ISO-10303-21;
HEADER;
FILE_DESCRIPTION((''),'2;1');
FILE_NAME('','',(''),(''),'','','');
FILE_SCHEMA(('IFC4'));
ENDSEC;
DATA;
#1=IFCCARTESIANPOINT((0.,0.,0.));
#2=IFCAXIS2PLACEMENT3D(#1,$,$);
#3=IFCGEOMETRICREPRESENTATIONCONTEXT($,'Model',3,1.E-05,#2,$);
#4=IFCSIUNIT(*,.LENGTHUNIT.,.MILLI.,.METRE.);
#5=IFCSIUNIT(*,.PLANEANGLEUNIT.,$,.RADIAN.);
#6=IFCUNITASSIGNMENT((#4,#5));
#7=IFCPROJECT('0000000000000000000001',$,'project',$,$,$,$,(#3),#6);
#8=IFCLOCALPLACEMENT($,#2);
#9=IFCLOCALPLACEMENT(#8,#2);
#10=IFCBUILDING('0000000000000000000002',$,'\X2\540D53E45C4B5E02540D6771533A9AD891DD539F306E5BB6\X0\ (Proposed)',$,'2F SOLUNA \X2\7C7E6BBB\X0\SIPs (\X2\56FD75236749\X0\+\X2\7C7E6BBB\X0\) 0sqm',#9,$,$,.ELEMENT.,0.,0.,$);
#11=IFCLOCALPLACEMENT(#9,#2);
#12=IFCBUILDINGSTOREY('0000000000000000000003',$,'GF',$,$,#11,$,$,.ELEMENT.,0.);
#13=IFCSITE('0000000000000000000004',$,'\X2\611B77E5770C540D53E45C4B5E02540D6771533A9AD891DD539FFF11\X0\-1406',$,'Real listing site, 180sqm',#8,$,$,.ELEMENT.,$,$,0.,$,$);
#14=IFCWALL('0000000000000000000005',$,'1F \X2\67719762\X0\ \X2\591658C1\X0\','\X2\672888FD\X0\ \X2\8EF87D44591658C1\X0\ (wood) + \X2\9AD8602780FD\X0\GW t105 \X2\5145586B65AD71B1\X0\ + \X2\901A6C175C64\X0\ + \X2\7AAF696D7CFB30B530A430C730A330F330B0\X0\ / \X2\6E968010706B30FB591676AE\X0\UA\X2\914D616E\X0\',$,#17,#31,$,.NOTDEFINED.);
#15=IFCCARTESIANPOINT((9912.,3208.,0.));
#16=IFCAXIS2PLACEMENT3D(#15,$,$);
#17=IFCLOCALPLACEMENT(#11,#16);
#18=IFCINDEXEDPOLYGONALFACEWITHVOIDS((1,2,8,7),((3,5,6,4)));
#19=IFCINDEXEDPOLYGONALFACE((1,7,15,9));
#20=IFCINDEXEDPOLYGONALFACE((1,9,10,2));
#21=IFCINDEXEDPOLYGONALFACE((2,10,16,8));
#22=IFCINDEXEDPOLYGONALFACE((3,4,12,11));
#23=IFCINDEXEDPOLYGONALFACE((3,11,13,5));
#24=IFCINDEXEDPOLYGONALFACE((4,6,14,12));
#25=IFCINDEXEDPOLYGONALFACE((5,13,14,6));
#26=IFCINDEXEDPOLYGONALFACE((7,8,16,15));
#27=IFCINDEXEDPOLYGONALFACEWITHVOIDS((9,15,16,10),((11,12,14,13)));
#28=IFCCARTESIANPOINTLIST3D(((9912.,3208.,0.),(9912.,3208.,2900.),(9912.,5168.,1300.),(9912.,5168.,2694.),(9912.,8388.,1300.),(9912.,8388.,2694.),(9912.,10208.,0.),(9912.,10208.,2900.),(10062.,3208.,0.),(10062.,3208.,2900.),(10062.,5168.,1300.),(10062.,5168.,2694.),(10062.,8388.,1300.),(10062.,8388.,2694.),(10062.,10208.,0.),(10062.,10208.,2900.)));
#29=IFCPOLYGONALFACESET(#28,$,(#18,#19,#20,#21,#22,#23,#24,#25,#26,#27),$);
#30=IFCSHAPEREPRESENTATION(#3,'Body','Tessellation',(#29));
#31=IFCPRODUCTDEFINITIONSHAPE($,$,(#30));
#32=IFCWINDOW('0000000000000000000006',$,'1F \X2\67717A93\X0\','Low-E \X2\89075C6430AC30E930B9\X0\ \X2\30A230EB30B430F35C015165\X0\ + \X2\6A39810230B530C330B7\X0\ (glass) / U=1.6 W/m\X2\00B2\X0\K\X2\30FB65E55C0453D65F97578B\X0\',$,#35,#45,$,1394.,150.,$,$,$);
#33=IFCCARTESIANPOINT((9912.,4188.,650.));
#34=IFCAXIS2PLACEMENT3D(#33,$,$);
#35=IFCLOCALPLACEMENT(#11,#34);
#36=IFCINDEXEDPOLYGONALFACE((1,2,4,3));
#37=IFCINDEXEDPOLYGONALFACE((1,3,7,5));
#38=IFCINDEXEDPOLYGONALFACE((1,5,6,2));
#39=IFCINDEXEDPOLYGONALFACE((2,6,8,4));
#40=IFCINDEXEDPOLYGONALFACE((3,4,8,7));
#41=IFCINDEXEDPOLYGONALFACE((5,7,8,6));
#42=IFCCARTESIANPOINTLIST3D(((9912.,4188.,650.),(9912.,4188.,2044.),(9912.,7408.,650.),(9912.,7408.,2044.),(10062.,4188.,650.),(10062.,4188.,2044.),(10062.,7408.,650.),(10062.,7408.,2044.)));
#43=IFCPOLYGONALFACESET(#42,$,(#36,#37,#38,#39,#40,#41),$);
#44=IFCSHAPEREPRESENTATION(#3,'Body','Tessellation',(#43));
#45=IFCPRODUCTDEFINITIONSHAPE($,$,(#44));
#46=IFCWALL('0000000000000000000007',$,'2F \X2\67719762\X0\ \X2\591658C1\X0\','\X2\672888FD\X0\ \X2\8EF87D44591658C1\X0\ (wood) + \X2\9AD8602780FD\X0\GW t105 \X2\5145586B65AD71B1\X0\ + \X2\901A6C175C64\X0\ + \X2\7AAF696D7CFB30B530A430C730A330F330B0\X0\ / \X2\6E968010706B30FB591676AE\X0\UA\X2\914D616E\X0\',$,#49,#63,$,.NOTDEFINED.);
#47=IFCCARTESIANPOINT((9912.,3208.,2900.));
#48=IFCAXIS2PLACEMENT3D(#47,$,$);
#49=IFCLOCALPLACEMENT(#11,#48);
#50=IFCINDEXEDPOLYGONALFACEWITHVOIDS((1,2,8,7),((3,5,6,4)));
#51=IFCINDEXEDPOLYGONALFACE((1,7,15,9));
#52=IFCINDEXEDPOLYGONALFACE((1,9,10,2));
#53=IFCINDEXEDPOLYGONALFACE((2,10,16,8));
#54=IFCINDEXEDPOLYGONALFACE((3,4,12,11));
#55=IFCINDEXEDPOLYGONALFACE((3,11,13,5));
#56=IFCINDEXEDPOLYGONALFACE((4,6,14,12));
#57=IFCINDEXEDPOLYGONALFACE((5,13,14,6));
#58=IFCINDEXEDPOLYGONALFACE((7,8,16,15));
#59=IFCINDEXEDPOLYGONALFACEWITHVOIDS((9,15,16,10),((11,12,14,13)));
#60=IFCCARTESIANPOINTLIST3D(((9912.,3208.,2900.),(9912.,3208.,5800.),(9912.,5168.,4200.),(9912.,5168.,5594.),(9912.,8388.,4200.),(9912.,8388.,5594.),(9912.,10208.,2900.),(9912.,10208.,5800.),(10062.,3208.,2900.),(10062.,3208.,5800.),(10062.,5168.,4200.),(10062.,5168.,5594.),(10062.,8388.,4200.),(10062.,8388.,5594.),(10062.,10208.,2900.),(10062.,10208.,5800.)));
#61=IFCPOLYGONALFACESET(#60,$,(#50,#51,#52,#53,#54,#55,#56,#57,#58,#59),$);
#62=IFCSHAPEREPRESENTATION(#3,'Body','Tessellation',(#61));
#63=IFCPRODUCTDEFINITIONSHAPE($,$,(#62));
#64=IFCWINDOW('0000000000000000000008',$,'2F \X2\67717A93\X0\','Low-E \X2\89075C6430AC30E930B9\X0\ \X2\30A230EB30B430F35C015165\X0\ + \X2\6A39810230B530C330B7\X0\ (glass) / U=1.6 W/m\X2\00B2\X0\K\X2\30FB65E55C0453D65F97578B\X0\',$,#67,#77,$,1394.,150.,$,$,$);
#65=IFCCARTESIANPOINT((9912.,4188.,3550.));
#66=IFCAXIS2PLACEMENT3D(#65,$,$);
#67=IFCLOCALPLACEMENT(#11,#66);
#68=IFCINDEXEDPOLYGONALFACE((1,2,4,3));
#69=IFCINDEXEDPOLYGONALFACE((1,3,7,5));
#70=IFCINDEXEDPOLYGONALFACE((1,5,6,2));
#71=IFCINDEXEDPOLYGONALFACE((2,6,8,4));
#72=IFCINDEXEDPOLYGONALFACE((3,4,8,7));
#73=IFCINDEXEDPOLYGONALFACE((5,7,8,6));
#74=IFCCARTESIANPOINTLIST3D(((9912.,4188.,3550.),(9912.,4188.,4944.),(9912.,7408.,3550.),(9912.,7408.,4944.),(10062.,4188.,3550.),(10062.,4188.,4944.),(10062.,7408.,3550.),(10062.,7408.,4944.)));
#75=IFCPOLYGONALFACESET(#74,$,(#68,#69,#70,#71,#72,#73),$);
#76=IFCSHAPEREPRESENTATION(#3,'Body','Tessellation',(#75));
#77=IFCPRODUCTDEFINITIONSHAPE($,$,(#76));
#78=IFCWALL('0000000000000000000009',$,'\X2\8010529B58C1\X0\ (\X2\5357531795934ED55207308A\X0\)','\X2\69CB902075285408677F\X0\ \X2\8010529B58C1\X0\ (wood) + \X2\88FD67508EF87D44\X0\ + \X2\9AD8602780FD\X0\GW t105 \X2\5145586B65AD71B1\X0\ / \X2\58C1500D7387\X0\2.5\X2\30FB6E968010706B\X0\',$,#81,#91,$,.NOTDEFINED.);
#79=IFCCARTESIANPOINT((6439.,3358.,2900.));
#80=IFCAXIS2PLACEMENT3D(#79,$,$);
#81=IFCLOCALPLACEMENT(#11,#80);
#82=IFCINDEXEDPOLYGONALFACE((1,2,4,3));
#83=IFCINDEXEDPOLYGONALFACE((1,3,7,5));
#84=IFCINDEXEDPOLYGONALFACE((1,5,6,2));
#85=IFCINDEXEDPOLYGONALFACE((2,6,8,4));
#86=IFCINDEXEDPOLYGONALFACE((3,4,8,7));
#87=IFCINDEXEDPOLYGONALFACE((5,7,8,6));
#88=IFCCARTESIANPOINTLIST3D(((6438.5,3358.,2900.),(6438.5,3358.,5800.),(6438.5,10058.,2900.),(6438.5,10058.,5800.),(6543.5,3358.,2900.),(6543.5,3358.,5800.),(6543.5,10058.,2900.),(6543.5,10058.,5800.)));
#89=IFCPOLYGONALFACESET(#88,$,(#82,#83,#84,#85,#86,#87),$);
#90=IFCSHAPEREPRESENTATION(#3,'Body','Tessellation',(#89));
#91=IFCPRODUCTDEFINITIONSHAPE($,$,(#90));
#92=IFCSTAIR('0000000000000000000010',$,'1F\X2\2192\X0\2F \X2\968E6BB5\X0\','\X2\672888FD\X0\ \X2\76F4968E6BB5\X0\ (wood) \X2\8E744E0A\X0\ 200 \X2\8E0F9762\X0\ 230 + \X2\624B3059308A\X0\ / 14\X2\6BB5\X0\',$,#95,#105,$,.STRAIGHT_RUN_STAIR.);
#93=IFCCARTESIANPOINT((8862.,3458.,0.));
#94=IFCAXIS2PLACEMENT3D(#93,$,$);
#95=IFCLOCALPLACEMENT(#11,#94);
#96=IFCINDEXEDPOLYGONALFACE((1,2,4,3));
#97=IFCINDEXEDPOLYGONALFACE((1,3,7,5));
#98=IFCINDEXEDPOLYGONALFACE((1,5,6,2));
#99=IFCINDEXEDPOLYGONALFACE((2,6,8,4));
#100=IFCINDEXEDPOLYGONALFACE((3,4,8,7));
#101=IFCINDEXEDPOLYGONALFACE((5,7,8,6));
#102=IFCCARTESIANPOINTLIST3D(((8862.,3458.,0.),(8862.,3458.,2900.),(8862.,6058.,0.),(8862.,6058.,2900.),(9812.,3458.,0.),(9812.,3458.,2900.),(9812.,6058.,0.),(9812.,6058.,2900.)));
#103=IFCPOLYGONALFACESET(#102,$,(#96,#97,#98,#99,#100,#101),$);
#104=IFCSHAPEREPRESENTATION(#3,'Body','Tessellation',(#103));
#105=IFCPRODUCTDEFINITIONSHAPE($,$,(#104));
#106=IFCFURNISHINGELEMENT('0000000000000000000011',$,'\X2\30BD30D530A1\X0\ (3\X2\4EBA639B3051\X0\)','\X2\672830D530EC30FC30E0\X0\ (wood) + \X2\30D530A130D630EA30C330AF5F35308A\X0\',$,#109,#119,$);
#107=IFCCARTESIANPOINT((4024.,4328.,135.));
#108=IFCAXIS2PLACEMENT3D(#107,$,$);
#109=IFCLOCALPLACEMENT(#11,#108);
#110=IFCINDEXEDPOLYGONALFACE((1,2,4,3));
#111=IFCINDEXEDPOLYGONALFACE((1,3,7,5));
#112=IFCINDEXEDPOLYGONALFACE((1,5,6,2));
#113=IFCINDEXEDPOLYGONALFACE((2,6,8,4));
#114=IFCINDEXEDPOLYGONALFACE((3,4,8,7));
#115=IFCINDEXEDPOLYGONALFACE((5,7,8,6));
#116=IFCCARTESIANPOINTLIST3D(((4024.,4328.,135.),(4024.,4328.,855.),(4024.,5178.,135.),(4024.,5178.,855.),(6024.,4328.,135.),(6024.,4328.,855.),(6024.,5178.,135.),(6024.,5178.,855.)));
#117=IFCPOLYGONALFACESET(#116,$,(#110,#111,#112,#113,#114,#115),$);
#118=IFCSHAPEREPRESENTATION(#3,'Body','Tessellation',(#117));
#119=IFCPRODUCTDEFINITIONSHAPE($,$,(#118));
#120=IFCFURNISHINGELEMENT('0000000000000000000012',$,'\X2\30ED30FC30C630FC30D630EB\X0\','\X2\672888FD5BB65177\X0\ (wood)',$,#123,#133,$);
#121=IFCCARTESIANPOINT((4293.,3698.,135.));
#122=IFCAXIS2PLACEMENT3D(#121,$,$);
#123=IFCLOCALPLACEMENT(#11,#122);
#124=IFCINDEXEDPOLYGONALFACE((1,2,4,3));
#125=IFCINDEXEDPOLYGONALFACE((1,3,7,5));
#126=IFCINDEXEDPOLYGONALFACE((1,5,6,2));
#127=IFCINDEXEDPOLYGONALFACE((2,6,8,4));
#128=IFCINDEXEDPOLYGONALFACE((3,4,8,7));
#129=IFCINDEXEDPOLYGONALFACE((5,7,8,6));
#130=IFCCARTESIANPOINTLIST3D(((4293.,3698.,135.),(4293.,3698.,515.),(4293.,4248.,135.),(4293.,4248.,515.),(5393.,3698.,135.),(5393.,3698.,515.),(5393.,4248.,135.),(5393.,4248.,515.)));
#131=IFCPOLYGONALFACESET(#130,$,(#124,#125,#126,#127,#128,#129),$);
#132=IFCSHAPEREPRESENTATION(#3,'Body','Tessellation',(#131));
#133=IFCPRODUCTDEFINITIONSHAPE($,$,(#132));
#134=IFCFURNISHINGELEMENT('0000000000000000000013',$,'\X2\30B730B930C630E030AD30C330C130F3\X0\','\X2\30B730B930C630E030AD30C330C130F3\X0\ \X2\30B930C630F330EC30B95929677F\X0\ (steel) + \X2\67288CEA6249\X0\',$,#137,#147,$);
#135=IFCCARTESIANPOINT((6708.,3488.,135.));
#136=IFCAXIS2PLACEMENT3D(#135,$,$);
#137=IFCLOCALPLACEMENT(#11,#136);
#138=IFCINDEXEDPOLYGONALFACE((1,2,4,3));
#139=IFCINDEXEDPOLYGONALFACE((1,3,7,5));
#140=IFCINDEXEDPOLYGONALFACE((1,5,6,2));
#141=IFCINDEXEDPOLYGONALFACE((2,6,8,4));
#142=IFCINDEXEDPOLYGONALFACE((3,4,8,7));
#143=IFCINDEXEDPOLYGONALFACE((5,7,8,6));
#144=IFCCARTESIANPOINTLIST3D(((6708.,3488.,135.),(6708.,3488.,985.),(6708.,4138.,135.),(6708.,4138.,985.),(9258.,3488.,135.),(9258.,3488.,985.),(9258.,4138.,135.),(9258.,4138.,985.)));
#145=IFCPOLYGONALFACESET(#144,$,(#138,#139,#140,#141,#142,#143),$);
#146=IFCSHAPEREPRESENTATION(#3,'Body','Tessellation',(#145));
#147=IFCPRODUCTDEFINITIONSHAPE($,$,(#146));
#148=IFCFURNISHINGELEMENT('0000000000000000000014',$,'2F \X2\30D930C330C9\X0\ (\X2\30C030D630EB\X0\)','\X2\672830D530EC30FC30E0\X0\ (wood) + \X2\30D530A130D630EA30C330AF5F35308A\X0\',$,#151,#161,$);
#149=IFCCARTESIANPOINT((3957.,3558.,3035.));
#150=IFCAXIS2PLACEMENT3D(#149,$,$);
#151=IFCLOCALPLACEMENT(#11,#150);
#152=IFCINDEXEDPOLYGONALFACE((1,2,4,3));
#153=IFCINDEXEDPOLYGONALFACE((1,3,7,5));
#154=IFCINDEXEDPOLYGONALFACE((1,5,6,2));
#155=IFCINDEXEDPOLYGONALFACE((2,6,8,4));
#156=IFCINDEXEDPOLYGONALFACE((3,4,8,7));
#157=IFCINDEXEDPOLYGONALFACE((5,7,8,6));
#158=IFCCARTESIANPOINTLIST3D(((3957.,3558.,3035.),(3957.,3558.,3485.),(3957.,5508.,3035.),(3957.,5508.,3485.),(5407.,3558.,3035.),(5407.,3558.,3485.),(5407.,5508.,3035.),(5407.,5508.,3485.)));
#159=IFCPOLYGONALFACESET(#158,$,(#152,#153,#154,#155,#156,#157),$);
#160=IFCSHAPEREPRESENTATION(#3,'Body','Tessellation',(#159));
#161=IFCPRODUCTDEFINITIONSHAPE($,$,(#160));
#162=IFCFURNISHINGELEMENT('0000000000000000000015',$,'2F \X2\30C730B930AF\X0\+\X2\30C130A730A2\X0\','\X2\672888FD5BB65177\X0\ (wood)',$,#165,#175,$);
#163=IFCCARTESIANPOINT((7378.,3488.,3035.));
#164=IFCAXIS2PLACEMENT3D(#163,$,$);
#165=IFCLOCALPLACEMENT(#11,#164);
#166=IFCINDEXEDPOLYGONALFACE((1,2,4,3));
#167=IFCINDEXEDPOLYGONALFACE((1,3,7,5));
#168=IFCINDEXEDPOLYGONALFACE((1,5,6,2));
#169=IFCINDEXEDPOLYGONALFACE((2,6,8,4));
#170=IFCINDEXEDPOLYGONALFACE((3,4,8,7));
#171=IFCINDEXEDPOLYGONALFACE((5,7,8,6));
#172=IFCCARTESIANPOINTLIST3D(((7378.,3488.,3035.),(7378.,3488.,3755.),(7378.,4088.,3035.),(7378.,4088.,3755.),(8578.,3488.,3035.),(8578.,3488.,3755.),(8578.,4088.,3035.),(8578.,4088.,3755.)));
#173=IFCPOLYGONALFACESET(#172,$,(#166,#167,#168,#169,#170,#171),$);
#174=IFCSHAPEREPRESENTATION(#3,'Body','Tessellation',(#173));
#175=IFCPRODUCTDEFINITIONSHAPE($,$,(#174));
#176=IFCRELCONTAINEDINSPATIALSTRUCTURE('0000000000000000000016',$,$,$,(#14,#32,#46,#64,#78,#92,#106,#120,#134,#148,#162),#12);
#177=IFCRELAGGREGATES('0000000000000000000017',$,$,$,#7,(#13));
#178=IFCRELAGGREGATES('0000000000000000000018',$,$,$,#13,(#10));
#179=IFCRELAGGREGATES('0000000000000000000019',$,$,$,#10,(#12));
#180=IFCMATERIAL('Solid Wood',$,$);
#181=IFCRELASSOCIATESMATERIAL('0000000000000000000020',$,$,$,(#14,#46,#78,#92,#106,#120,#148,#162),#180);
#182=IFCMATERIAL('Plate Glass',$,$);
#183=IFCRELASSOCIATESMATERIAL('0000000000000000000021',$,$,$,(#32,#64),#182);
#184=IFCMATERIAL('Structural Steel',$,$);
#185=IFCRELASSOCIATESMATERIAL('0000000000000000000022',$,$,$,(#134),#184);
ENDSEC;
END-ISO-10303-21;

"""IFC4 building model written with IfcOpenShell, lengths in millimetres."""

from ifc_helpers import new_model, si_unit, frame, frame_2d, origin, place, context, project, spatial, rectangle, extrude, material, element, fill, save


model = new_model("IFC4")

# Units and contexts
model_context = context("Model", 3, precision=1e-05, world=origin())
ifc_project = project(units=[si_unit("LENGTHUNIT", "METRE", prefix="MILLI"), si_unit("PLANEANGLEUNIT", "RADIAN")], contexts=[model_context])

# Site, building, storey
site_placement = place(None, origin())
site = spatial("IfcSite", under=ifc_project, at=site_placement, Name="愛知県名古屋市名東区高針原１-1406", ObjectType="Real listing site, 180sqm", CompositionType="ELEMENT", RefElevation=0.0)
building_placement = place(site_placement, origin())
building = spatial("IfcBuilding", under=site, at=building_placement, Name="名古屋市名東区高針原の家 (Proposed)", ObjectType="2F SOLUNA 籾殻SIPs (国産杉+籾殻) 0sqm", CompositionType="ELEMENT", ElevationOfRefHeight=0.0, ElevationOfTerrain=0.0)
storey_placement = place(building_placement, origin())
storey = spatial("IfcBuildingStorey", under=building, at=storey_placement, Name="GF", CompositionType="ELEMENT", Elevation=0.0)

# Wall, opening, window
ifc_material_1 = material(Name="Solid Wood")
wall_1_placement = place(storey_placement, frame((9912.0, 3208.0, 0.0)))
wall_1 = element("IfcWall", 1, at=wall_1_placement, inside=storey, material=ifc_material_1, Name="1F 東面 外壁", Description="木製 軸組外壁 (wood) + 高性能GW t105 充填断熱 + 通気層 + 窯業系サイディング / 準耐火・外皮UA配慮", PredefinedType="NOTDEFINED", context=model_context, shape_type="SweptSolid", body=[
    extrude(rectangle(XDim=150.0, YDim=7000.0, at=frame_2d((75.0, 3500.0))), frame((9912.0, 3208.0, 0.0)), (0.0, 0.0, 1.0), 2900.0),
])
opening_1_placement = place(storey_placement, frame((9912.0, 4188.0, 650.0)))
opening_1 = element("IfcOpeningElement", 2, at=opening_1_placement, cuts=wall_1, PredefinedType="NOTDEFINED", context=model_context, shape_type="SweptSolid", body=[
    extrude(rectangle(XDim=150.0, YDim=3220.0, at=frame_2d((75.0, 1610.0))), frame((9912.0, 4188.0, 650.0)), (0.0, 0.0, 1.0), 1394.0),
])
ifc_material_2 = material(Name="Plate Glass")
window_1_placement = place(storey_placement, frame((9912.0, 4188.0, 650.0)))
window_1 = element("IfcWindow", 3, at=window_1_placement, inside=storey, material=ifc_material_2, Name="1F 東窓", Description="Low-E 複層ガラス アルゴン封入 + 樹脂サッシ (glass) / U=1.6 W/m²K・日射取得型", OverallHeight=1394.0, OverallWidth=150.0, context=model_context, shape_type="SweptSolid", body=[
    extrude(rectangle(XDim=150.0, YDim=3220.0, at=frame_2d((75.0, 1610.0))), frame((9912.0, 4188.0, 650.0)), (0.0, 0.0, 1.0), 1394.0),
])
fill(opening_1, window_1)

# Wall, opening, window
wall_2_placement = place(storey_placement, frame((9912.0, 3208.0, 2900.0)))
wall_2 = element("IfcWall", 4, at=wall_2_placement, inside=storey, material=ifc_material_1, Name="2F 東面 外壁", Description="木製 軸組外壁 (wood) + 高性能GW t105 充填断熱 + 通気層 + 窯業系サイディング / 準耐火・外皮UA配慮", PredefinedType="NOTDEFINED", context=model_context, shape_type="SweptSolid", body=[
    extrude(rectangle(XDim=150.0, YDim=7000.0, at=frame_2d((75.0, 3500.0))), frame((9912.0, 3208.0, 2900.0)), (0.0, 0.0, 1.0), 2900.0),
])
opening_2_placement = place(storey_placement, frame((9912.0, 4188.0, 3550.0)))
opening_2 = element("IfcOpeningElement", 5, at=opening_2_placement, cuts=wall_2, PredefinedType="NOTDEFINED", context=model_context, shape_type="SweptSolid", body=[
    extrude(rectangle(XDim=150.0, YDim=3220.0, at=frame_2d((75.0, 1610.0))), frame((9912.0, 4188.0, 3550.0)), (0.0, 0.0, 1.0), 1394.0),
])
window_2_placement = place(storey_placement, frame((9912.0, 4188.0, 3550.0)))
window_2 = element("IfcWindow", 6, at=window_2_placement, inside=storey, material=ifc_material_2, Name="2F 東窓", Description="Low-E 複層ガラス アルゴン封入 + 樹脂サッシ (glass) / U=1.6 W/m²K・日射取得型", OverallHeight=1394.0, OverallWidth=150.0, context=model_context, shape_type="SweptSolid", body=[
    extrude(rectangle(XDim=150.0, YDim=3220.0, at=frame_2d((75.0, 1610.0))), frame((9912.0, 4188.0, 3550.0)), (0.0, 0.0, 1.0), 1394.0),
])
fill(opening_2, window_2)

# Wall
wall_3_placement = place(storey_placement, frame((6439.0, 3358.0, 2900.0)))
element("IfcWall", 7, at=wall_3_placement, inside=storey, material=ifc_material_1, Name="耐力壁 (南北間仕切り)", Description="構造用合板 耐力壁 (wood) + 製材軸組 + 高性能GW t105 充填断熱 / 壁倍率2.5・準耐火", PredefinedType="NOTDEFINED", context=model_context, shape_type="SweptSolid", body=[
    extrude(rectangle(XDim=105.0, YDim=6700.0, at=frame_2d((52.0, 3350.0))), frame((6439.0, 3358.0, 2900.0)), (0.0, 0.0, 1.0), 2900.0),
])

# Stair
stair_placement = place(storey_placement, frame((8862.0, 3458.0, 0.0)))
element("IfcStair", 8, at=stair_placement, inside=storey, material=ifc_material_1, Name="1F→2F 階段", Description="木製 直階段 (wood) 蹴上 200 踏面 230 + 手すり / 14段", PredefinedType="STRAIGHT_RUN_STAIR", context=model_context, shape_type="SweptSolid", body=[
    extrude(rectangle(XDim=950.0, YDim=2600.0, at=frame_2d((475.0, 1300.0))), frame((8862.0, 3458.0, 0.0)), (0.0, 0.0, 1.0), 2900.0),
])

# Furnishing elements
furnishing_1_placement = place(storey_placement, frame((4024.0, 4328.0, 135.0)))
element("IfcFurnishingElement", 9, at=furnishing_1_placement, inside=storey, material=ifc_material_1, Name="ソファ (3人掛け)", Description="木フレーム (wood) + ファブリック張り", context=model_context, shape_type="SweptSolid", body=[
    extrude(rectangle(XDim=2000.0, YDim=850.0, at=frame_2d((1000.0, 425.0))), frame((4024.0, 4328.0, 135.0)), (0.0, 0.0, 1.0), 720.0),
])
furnishing_2_placement = place(storey_placement, frame((4293.0, 3698.0, 135.0)))
element("IfcFurnishingElement", 10, at=furnishing_2_placement, inside=storey, material=ifc_material_1, Name="ローテーブル", Description="木製家具 (wood)", context=model_context, shape_type="SweptSolid", body=[
    extrude(rectangle(XDim=1100.0, YDim=550.0, at=frame_2d((550.0, 275.0))), frame((4293.0, 3698.0, 135.0)), (0.0, 0.0, 1.0), 380.0),
])
ifc_material_3 = material(Name="Structural Steel")
furnishing_3_placement = place(storey_placement, frame((6708.0, 3488.0, 135.0)))
element("IfcFurnishingElement", 11, at=furnishing_3_placement, inside=storey, material=ifc_material_3, Name="システムキッチン", Description="システムキッチン ステンレス天板 (steel) + 木質扉", context=model_context, shape_type="SweptSolid", body=[
    extrude(rectangle(XDim=2550.0, YDim=650.0, at=frame_2d((1275.0, 325.0))), frame((6708.0, 3488.0, 135.0)), (0.0, 0.0, 1.0), 850.0),
])
furnishing_4_placement = place(storey_placement, frame((3957.0, 3558.0, 3035.0)))
element("IfcFurnishingElement", 12, at=furnishing_4_placement, inside=storey, material=ifc_material_1, Name="2F ベッド (ダブル)", Description="木フレーム (wood) + ファブリック張り", context=model_context, shape_type="SweptSolid", body=[
    extrude(rectangle(XDim=1450.0, YDim=1950.0, at=frame_2d((725.0, 975.0))), frame((3957.0, 3558.0, 3035.0)), (0.0, 0.0, 1.0), 450.0),
])
furnishing_5_placement = place(storey_placement, frame((7378.0, 3488.0, 3035.0)))
element("IfcFurnishingElement", 13, at=furnishing_5_placement, inside=storey, material=ifc_material_1, Name="2F デスク+チェア", Description="木製家具 (wood)", context=model_context, shape_type="SweptSolid", body=[
    extrude(rectangle(XDim=1200.0, YDim=600.0, at=frame_2d((600.0, 300.0))), frame((7378.0, 3488.0, 3035.0)), (0.0, 0.0, 1.0), 720.0),
])

save(model, "model.ifc")
